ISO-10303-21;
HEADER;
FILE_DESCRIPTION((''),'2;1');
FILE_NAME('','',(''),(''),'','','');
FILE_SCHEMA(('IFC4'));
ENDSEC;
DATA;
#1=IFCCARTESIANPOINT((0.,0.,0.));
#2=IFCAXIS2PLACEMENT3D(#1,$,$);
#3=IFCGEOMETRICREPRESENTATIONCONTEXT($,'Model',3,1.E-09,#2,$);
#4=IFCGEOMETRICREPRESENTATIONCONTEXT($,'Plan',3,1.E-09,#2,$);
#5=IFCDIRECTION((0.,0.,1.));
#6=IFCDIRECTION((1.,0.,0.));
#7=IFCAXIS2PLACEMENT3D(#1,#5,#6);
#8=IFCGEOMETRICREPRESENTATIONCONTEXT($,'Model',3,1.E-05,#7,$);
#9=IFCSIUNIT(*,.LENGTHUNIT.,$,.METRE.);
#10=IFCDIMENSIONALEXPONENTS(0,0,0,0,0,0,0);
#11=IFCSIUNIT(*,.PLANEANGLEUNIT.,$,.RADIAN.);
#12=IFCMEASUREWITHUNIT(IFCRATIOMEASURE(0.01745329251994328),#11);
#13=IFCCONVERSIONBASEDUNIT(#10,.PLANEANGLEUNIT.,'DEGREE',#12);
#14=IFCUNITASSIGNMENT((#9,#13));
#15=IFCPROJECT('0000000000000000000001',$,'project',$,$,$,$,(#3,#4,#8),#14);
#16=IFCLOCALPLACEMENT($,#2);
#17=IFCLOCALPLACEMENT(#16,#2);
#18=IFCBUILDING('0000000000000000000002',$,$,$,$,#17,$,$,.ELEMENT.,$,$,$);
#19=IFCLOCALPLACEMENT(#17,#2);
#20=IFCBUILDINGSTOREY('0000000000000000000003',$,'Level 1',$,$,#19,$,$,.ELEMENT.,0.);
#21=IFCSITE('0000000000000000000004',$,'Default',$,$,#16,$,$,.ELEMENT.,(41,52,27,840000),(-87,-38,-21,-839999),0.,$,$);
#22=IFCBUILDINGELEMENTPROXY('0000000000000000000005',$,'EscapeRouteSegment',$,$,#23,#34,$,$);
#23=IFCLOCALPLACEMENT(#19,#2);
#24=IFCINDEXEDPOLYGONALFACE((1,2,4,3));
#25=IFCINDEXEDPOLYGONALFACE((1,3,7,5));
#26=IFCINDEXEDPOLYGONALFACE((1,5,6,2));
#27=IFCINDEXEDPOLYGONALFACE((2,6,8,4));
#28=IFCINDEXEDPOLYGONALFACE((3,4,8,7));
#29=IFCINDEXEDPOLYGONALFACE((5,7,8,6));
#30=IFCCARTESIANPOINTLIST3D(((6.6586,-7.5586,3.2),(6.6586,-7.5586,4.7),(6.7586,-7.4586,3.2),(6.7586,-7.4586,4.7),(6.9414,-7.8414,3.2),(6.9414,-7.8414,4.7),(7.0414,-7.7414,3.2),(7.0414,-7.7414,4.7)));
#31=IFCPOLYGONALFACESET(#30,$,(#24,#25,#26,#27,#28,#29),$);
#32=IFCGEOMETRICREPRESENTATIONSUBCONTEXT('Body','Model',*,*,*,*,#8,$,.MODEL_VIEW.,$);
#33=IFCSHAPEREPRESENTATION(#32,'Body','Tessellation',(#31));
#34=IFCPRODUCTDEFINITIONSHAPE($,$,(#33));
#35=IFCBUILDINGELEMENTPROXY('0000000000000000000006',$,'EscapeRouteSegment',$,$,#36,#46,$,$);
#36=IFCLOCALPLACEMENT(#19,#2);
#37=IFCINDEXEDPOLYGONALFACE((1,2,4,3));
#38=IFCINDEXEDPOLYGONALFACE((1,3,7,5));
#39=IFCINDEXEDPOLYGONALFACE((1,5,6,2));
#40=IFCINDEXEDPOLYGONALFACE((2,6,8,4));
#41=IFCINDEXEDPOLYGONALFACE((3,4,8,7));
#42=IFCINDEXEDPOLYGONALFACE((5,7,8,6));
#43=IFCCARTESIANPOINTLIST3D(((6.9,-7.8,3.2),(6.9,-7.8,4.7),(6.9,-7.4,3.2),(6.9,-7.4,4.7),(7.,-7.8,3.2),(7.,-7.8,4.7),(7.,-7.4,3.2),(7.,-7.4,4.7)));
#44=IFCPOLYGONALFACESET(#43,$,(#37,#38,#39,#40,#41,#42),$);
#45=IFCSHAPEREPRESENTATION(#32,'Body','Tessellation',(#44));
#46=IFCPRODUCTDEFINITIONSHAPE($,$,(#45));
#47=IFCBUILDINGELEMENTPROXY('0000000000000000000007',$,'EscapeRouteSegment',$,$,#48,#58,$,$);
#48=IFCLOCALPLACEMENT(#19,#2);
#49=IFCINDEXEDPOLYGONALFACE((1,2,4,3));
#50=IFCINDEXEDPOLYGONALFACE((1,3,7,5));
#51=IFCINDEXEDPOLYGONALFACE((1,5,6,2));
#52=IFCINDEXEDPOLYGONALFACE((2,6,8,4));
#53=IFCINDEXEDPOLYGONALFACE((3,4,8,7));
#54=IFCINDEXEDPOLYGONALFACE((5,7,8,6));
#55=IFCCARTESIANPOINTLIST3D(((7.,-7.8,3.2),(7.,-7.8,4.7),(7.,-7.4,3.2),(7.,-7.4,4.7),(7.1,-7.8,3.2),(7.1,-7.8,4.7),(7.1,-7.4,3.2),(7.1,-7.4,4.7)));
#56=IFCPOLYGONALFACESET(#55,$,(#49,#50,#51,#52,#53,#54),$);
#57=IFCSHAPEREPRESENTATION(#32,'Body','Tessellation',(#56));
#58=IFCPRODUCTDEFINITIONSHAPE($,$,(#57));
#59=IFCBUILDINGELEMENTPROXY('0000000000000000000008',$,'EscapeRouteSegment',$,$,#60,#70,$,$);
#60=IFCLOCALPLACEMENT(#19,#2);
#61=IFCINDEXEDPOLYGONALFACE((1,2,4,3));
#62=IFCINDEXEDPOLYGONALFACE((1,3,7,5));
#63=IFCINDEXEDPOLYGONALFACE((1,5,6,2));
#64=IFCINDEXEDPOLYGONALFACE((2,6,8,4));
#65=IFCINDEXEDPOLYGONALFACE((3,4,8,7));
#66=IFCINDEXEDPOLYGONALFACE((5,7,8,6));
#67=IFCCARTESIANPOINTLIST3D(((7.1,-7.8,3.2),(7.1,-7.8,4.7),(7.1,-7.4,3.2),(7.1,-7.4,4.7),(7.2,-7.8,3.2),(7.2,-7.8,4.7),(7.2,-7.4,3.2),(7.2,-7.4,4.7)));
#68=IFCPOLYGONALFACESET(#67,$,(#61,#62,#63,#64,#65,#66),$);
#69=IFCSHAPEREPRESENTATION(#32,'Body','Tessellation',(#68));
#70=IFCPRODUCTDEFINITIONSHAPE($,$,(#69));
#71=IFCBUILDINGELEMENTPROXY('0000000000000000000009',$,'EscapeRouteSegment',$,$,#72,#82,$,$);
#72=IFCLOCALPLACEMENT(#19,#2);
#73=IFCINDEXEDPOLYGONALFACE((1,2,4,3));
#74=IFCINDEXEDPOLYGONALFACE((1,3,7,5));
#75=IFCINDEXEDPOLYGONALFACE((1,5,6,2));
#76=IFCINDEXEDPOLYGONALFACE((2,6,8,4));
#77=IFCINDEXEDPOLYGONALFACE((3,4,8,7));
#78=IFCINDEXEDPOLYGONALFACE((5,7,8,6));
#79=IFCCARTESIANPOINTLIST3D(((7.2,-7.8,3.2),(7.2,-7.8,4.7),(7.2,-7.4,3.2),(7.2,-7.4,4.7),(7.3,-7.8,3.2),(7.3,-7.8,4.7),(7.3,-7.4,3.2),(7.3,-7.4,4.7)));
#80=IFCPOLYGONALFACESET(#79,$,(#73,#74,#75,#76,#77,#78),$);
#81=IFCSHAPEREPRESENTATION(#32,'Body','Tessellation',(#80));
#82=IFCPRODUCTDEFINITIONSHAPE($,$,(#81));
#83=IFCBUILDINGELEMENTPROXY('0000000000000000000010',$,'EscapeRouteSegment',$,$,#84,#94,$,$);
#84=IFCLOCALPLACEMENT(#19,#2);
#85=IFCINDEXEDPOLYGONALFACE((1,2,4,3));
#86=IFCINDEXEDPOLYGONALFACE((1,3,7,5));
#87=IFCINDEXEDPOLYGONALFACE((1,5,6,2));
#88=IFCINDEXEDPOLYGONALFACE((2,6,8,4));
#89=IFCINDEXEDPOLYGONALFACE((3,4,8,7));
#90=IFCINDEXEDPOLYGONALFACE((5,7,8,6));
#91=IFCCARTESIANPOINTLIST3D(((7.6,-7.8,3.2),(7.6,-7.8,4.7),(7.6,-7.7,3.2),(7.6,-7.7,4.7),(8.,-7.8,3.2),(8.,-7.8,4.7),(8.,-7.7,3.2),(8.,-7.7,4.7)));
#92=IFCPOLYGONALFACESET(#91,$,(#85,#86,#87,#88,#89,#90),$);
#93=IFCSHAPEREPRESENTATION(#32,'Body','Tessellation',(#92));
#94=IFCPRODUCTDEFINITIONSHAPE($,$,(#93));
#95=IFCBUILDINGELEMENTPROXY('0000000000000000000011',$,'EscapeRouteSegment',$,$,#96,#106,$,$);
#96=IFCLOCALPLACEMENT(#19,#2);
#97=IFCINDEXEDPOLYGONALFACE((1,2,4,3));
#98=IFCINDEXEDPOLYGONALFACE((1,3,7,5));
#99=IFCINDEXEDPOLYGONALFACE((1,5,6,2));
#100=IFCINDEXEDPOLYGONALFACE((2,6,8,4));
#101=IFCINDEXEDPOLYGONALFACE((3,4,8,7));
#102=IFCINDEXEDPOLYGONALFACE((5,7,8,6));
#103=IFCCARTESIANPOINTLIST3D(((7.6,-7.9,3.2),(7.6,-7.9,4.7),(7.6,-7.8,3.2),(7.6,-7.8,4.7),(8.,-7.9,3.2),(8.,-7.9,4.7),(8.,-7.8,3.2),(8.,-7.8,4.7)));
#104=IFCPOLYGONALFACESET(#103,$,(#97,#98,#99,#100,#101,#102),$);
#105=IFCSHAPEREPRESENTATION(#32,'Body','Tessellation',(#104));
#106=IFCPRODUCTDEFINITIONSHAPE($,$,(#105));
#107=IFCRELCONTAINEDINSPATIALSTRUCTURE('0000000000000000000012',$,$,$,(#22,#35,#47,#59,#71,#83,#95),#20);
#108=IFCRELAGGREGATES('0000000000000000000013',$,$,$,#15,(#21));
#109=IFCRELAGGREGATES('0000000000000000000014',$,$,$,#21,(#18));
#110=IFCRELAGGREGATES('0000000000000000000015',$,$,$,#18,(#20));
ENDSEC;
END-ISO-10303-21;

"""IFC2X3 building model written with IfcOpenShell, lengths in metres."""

from ifc_helpers import new_model, entity, si_unit, converted_unit, frame, origin, origin_with_axes, place, context, subcontext, project, spatial, polyline, outline, extrude, element, save


model = new_model("IFC2X3")

# Units and contexts
model_context_1 = context("Model", 3, precision=1e-09, world=origin())
plan_context = context("Plan", 3, precision=1e-09, world=origin())
model_context_2 = context("Model", 3, precision=1e-05, world=origin_with_axes())
body_context = subcontext(model_context_2, "Body", "Model", "MODEL_VIEW")
ifc_project = project(units=[si_unit("LENGTHUNIT", "METRE"), converted_unit("PLANEANGLEUNIT", "DEGREE", entity("IfcRatioMeasure", 0.01745329251994328), si_unit("PLANEANGLEUNIT", "RADIAN"), dimensions=[0, 0, 0, 0, 0, 0, 0])], contexts=[model_context_1, plan_context, model_context_2])

# Site, building, storey
site_placement = place(None, origin())
site = spatial("IfcSite", under=ifc_project, at=site_placement, Name="Default", CompositionType="ELEMENT", RefLatitude=(41, 52, 27, 840000), RefLongitude=(-87, -38, -21, -839999), RefElevation=0.0)
building_placement = place(site_placement, origin())
building = spatial("IfcBuilding", under=site, at=building_placement, CompositionType="ELEMENT")
storey_placement = place(building_placement, origin())
storey = spatial("IfcBuildingStorey", under=building, at=storey_placement, Name="Level 1", CompositionType="ELEMENT", Elevation=0.0)

# Building element proxies
for number, where, z_axis, x_axis, name in (
    (1, (6.8, -7.7, 3.2), (0.0, 0.0, 1.0), (0.707107, 0.707107, 0.0), "EscapeRouteSegment"),
):
    element("IfcBuildingElementProxy", number, at=place(storey_placement, frame(where, z_axis=z_axis, x_axis=x_axis)), inside=storey, Name=name, context=body_context, shape_type="SweptSolid", body=[
        extrude(outline(polyline([(0.0, -0.2), (0.0, 0.2), (0.1414, 0.2), (0.1414, -0.2), (0.0, -0.2)])), origin_with_axes(), (0.0, 0.0, 1.0), 1.5),
    ])
for number, where, z_axis, x_axis, name in (
    (2, (6.9, -7.6, 3.2), (0.0, 0.0, 1.0), (1.0, 0.0, 0.0), "EscapeRouteSegment"),
    (3, (7.0, -7.6, 3.2), (0.0, 0.0, 1.0), (1.0, 0.0, 0.0), "EscapeRouteSegment"),
    (4, (7.1, -7.6, 3.2), (0.0, 0.0, 1.0), (1.0, 0.0, 0.0), "EscapeRouteSegment"),
):
    element("IfcBuildingElementProxy", number, at=place(storey_placement, frame(where, z_axis=z_axis, x_axis=x_axis)), inside=storey, Name=name, context=body_context, shape_type="SweptSolid", body=[
        extrude(outline(polyline([(0.0, -0.2), (0.0, 0.2), (0.1, 0.2), (0.1, -0.2), (0.0, -0.2)])), origin_with_axes(), (0.0, 0.0, 1.0), 1.5),
    ])
for number, where, z_axis, x_axis, name in (
    (5, (7.2, -7.6, 3.2), (0.0, 0.0, 1.0), (1.0, 0.0, 0.0), "EscapeRouteSegment"),
    (6, (7.8, -7.7, 3.2), (0.0, 0.0, 1.0), (0.0, -1.0, 0.0), "EscapeRouteSegment"),
):
    element("IfcBuildingElementProxy", number, at=place(storey_placement, frame(where, z_axis=z_axis, x_axis=x_axis)), inside=storey, Name=name, context=body_context, shape_type="SweptSolid", body=[
        extrude(outline(polyline([(0.0, -0.2), (0.0, 0.2), (0.1, 0.2), (0.1, -0.2), (0.0, -0.2)])), origin_with_axes(), (0.0, 0.0, 1.0), 1.5),
    ])
proxy_1_placement = place(storey_placement, frame((7.8, -7.8, 3.2), z_axis=(0.0, 0.0, 1.0), x_axis=(0.0, -1.0, 0.0)))
element("IfcBuildingElementProxy", 7, at=proxy_1_placement, inside=storey, Name="EscapeRouteSegment", context=body_context, shape_type="SweptSolid", body=[
    extrude(outline(polyline([(0.0, -0.2), (0.0, 0.2), (0.1, 0.2), (0.1, -0.2), (0.0, -0.2)])), origin_with_axes(), (0.0, 0.0, 1.0), 1.5),
])

save(model, "model.ifc")
